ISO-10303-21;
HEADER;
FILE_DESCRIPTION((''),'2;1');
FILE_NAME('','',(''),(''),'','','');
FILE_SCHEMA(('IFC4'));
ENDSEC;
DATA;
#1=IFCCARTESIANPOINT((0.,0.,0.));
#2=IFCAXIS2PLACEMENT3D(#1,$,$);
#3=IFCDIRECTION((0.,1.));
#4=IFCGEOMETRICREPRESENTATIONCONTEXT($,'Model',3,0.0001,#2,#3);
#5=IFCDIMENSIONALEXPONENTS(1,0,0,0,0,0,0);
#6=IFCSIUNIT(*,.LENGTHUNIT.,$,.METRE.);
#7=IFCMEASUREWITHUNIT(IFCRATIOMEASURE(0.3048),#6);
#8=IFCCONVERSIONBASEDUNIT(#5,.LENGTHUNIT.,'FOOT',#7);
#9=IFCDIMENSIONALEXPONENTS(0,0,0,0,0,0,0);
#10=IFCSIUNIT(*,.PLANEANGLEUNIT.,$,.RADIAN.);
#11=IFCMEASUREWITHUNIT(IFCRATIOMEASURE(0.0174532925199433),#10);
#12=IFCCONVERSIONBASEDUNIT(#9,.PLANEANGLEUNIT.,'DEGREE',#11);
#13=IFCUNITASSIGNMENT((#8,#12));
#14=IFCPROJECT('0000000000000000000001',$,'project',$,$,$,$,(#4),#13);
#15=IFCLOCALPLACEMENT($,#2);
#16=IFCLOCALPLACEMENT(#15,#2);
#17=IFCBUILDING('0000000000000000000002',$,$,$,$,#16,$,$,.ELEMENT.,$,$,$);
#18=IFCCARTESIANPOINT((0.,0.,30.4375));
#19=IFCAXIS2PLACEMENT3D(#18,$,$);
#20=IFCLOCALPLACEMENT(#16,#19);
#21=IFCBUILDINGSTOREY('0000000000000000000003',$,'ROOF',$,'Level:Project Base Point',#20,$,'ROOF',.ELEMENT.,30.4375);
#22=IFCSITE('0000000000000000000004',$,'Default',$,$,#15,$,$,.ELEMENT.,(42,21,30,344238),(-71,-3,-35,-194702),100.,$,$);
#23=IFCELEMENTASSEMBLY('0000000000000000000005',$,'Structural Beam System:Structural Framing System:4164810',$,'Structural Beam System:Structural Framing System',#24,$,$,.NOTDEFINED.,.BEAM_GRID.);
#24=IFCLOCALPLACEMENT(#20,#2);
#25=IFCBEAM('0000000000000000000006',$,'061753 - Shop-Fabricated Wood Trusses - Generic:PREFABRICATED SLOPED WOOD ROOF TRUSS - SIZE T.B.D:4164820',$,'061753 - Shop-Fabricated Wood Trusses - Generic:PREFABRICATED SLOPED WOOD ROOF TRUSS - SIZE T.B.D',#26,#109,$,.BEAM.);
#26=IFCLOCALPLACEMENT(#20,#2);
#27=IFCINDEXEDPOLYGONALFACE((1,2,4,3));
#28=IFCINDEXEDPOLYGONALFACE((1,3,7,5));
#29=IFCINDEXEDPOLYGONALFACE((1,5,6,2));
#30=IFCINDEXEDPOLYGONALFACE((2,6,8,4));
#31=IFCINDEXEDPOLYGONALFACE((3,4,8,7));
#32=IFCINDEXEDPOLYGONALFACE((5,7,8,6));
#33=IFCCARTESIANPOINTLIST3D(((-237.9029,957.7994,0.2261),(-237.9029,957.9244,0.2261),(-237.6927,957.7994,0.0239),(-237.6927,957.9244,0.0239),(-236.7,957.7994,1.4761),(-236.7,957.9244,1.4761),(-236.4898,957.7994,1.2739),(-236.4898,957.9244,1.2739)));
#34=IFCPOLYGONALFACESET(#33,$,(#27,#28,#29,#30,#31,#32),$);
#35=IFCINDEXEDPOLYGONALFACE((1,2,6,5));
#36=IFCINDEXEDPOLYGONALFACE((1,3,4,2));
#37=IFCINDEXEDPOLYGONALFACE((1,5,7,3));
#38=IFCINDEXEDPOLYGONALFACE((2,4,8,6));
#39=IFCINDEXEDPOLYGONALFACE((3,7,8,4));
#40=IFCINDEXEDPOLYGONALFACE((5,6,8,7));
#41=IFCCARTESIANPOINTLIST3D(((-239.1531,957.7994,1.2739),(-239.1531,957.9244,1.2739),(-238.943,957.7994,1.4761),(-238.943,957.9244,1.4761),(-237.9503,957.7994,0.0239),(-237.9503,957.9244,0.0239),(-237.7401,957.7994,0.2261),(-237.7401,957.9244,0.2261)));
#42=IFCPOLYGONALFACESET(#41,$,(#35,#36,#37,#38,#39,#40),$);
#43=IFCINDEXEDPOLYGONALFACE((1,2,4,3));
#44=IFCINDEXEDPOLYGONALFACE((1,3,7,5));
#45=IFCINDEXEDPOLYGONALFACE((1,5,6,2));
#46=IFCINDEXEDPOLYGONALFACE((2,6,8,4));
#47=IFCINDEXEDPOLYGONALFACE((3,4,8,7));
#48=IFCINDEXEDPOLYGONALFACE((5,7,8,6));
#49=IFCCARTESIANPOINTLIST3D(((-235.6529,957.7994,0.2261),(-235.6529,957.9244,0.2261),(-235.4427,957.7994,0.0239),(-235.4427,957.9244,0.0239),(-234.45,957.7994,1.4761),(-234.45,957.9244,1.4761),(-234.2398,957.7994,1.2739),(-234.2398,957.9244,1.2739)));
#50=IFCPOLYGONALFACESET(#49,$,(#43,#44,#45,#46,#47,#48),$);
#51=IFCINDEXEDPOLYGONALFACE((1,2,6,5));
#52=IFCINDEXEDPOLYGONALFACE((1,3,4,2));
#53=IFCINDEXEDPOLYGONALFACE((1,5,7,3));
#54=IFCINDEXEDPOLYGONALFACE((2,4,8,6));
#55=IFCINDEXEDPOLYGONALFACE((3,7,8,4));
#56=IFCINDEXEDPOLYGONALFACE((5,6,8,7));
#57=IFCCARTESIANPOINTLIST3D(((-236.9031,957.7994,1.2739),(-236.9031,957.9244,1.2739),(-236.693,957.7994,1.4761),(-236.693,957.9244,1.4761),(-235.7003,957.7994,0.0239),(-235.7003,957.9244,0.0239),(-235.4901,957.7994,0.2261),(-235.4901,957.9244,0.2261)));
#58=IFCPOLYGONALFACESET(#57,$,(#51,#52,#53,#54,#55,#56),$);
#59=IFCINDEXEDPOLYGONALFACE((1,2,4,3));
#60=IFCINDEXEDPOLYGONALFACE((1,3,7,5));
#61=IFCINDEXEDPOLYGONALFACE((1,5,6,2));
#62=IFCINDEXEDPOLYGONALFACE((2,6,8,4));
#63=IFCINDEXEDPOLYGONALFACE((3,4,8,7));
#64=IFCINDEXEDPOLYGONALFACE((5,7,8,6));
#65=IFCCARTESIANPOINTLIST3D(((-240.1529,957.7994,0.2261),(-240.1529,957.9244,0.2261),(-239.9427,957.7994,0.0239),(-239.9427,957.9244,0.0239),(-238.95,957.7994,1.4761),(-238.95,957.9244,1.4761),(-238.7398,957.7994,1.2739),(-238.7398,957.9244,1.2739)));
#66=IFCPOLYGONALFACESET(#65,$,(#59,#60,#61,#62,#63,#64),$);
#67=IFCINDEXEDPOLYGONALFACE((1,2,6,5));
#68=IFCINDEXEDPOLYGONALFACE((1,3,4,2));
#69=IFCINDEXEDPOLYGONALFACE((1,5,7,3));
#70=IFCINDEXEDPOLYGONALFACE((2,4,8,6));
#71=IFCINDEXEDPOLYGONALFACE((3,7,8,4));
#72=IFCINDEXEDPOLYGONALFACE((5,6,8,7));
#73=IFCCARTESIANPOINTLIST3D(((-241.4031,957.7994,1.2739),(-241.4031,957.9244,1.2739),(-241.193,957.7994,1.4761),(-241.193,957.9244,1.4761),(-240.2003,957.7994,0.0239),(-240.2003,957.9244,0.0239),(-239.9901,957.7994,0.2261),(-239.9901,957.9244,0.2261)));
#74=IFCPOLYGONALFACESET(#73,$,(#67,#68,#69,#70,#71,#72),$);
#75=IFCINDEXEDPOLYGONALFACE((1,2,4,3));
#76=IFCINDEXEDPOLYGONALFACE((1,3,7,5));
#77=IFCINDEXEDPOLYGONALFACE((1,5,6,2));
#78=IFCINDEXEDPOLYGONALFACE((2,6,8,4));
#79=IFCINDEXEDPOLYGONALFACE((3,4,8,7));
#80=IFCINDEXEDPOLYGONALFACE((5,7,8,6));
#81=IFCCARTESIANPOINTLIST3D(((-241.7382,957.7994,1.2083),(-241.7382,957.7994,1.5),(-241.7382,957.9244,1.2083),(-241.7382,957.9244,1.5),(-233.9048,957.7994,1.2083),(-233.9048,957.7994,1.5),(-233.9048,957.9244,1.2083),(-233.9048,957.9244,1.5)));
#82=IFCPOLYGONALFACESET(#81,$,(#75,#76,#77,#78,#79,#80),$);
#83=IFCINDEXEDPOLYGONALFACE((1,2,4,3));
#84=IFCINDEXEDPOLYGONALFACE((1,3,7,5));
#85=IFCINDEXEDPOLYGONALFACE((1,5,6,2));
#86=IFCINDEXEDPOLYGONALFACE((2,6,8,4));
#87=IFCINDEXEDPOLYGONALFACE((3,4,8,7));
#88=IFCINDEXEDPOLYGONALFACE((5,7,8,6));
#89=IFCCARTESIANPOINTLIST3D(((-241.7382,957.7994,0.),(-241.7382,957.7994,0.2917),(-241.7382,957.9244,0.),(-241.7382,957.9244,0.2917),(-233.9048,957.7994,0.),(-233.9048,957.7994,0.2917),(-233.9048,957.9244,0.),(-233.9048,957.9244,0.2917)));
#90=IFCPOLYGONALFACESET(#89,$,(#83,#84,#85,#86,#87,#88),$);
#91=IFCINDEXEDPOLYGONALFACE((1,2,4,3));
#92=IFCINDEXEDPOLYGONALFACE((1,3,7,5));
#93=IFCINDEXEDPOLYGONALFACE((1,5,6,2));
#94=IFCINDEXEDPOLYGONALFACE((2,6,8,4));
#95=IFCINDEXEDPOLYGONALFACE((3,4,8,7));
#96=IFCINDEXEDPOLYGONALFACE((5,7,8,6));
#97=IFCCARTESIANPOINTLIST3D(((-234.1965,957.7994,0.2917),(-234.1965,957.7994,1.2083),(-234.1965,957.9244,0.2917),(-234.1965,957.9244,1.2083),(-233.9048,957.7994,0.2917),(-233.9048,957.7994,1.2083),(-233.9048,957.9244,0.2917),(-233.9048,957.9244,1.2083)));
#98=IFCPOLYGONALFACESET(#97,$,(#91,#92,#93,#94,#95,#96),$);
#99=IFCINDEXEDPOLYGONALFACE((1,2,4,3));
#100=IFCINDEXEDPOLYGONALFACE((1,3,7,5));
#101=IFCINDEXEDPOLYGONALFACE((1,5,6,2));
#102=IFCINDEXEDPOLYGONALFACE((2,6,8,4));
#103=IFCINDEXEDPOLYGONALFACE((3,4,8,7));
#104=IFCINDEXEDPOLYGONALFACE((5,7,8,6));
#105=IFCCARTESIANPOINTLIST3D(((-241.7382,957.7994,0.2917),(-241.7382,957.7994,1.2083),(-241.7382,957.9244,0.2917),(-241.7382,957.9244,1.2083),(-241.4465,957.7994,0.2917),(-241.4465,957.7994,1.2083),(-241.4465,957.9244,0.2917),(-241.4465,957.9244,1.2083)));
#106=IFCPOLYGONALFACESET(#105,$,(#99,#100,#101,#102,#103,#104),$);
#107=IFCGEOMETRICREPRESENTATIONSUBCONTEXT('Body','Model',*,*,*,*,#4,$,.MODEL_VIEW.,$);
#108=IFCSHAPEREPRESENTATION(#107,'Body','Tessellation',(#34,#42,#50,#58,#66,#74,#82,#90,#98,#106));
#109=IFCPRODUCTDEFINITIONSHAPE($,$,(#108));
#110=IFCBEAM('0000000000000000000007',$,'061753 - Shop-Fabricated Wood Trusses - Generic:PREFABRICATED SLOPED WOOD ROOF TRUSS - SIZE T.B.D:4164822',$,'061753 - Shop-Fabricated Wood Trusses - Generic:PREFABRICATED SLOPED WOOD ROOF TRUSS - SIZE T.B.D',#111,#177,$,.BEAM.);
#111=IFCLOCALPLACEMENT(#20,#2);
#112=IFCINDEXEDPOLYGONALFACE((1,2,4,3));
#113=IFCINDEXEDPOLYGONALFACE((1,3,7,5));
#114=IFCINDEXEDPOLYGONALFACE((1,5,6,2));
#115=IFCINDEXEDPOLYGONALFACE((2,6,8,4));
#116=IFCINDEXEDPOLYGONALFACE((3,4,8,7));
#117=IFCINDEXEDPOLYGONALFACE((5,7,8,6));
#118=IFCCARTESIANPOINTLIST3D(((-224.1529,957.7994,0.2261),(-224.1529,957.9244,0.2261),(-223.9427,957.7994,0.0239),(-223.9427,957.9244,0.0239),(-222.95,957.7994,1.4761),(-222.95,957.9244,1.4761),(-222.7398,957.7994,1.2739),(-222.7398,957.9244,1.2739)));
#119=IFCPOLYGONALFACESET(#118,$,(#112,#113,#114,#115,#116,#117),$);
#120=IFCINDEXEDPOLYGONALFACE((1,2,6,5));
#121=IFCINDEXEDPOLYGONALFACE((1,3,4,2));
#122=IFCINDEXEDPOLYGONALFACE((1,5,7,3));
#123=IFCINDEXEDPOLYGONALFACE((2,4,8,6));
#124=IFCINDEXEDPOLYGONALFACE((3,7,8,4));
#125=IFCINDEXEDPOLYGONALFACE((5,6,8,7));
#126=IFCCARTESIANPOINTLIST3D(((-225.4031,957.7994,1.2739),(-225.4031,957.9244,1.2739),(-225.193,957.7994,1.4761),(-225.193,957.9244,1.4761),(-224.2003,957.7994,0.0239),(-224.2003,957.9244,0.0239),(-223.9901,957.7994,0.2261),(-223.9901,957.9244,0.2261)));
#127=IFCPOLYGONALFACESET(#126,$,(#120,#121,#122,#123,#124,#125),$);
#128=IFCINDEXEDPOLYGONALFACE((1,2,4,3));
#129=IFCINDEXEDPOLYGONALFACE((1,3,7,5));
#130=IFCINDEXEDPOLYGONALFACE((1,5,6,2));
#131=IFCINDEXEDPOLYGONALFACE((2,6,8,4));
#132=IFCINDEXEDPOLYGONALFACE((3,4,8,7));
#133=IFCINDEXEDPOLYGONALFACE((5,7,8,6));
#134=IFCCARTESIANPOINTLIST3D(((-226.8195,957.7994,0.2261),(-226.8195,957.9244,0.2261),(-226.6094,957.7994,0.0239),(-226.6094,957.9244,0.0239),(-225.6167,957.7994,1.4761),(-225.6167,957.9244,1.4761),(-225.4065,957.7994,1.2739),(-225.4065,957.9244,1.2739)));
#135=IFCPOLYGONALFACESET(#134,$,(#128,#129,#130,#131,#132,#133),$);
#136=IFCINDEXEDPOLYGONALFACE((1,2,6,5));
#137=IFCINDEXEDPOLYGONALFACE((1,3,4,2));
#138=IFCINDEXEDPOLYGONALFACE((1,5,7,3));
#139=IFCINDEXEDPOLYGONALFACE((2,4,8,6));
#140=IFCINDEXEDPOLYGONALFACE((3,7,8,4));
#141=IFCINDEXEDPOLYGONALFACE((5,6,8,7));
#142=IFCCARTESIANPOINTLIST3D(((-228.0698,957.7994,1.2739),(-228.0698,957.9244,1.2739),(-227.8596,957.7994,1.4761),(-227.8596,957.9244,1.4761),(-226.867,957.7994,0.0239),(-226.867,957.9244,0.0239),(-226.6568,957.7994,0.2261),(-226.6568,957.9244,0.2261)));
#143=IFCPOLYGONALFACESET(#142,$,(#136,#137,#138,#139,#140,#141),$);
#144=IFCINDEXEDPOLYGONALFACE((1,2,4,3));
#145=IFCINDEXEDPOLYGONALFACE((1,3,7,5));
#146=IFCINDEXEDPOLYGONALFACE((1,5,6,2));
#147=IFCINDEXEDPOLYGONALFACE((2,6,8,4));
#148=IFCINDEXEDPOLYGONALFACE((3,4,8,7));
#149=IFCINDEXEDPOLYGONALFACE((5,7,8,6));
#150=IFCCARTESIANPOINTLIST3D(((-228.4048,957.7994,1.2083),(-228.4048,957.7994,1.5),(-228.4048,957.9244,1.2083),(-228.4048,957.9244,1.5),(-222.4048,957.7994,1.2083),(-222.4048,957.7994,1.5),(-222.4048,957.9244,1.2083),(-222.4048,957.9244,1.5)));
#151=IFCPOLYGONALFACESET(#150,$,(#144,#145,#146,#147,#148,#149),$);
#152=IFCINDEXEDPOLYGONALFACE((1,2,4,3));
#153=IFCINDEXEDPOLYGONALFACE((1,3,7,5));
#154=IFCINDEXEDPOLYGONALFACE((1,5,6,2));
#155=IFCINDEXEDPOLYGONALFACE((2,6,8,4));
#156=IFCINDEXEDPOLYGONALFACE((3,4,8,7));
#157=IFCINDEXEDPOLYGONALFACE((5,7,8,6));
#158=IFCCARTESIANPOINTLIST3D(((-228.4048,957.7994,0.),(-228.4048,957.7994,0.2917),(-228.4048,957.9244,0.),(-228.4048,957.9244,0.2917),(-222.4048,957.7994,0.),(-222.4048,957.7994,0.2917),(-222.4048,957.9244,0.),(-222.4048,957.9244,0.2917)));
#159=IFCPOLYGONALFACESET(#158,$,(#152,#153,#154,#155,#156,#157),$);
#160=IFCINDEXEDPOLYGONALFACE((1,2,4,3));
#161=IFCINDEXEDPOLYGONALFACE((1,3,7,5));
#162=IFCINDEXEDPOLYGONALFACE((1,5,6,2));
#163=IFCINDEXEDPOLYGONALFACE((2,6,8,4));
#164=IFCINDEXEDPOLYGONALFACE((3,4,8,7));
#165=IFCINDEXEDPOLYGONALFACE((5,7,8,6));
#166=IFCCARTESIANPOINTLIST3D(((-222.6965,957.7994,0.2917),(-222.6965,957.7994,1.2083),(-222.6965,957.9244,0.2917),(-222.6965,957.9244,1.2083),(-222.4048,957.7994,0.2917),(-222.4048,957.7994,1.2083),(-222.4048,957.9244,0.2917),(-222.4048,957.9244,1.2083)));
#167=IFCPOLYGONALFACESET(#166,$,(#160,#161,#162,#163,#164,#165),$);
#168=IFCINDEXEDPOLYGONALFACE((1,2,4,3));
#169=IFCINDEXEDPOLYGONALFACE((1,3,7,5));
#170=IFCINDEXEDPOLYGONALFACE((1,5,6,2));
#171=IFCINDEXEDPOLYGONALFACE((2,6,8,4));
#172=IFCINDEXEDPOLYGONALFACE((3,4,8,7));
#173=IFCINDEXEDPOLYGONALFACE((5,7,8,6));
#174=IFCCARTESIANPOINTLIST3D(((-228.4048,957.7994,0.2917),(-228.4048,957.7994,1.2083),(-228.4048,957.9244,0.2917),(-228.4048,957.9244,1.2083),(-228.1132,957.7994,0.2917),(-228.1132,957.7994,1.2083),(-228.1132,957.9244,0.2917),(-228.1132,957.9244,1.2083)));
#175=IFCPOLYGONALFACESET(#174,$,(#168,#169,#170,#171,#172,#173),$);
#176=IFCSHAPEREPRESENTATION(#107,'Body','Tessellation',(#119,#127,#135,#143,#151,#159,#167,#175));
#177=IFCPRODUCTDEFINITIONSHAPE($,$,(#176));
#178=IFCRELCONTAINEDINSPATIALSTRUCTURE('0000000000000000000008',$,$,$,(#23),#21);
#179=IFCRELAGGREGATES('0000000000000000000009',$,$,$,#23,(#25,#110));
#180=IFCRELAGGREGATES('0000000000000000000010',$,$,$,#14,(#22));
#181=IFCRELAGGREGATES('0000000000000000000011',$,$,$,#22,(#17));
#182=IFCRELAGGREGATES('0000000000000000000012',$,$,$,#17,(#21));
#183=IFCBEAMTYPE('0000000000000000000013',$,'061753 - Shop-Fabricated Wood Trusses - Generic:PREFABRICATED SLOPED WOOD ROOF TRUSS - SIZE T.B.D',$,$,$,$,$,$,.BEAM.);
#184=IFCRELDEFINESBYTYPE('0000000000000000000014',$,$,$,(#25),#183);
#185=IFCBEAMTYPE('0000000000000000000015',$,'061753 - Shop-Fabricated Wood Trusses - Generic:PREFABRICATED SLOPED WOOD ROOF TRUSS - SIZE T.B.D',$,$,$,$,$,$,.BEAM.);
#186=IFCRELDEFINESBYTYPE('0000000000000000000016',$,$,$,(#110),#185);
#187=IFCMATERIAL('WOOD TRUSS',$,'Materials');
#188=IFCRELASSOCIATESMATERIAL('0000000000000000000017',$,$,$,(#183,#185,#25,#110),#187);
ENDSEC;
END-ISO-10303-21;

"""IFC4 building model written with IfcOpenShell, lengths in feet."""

from ifc_helpers import new_model, entity, si_unit, converted_unit, direction, frame, frame_2d, origin, origin_2d_with_axis, place, context, subcontext, project, spatial, rectangle, extrude, source, transform, mapped, material, material_profile, profile_set, profile_usage, type_object, type_shapes, element, aggregate, save


model = new_model("IFC4")

# Units and contexts
model_context = context("Model", 3, precision=0.0001, world=origin(), true_north=direction((0.0, 1.0)))
body_context = subcontext(model_context, "Body", "Model", "MODEL_VIEW")
ifc_project = project(units=[converted_unit("LENGTHUNIT", "FOOT", entity("IfcRatioMeasure", 0.3048), si_unit("LENGTHUNIT", "METRE"), dimensions=[1, 0, 0, 0, 0, 0, 0]), converted_unit("PLANEANGLEUNIT", "DEGREE", entity("IfcRatioMeasure", 0.0174532925199433), si_unit("PLANEANGLEUNIT", "RADIAN"), dimensions=[0, 0, 0, 0, 0, 0, 0])], contexts=[model_context])

# Site, building, storey
site_placement = place(None, origin())
site = spatial("IfcSite", under=ifc_project, at=site_placement, Name="Default", CompositionType="ELEMENT", RefLatitude=(42, 21, 30, 344238), RefLongitude=(-71, -3, -35, -194702), RefElevation=100.0)
building_placement = place(site_placement, origin())
building = spatial("IfcBuilding", under=site, at=building_placement, CompositionType="ELEMENT")
storey_placement = place(building_placement, frame((0.0, 0.0, 30.4375)))
storey = spatial("IfcBuildingStorey", under=building, at=storey_placement, Name="ROOF", ObjectType="Level:Project Base Point", LongName="ROOF", CompositionType="ELEMENT", Elevation=30.4375)

# Element assembly, beams
assembly_1_placement = place(storey_placement, origin())
assembly_1 = element("IfcElementAssembly", 1, at=assembly_1_placement, inside=storey, Name="Structural Beam System:Structural Framing System:4164810", ObjectType="Structural Beam System:Structural Framing System", AssemblyPlace="NOTDEFINED", PredefinedType="BEAM_GRID")
ifc_material_1 = material(Name="WOOD TRUSS", Category="Materials")
ifc_material_profile_1 = material_profile(ifc_material_1, rectangle(XDim=1.7347, YDim=0.125, at=origin_2d_with_axis()), Name="PREFABRICATED SLOPED WOOD ROOF TRUSS - SIZE T.B.D")
ifc_material_profile_2 = material_profile(ifc_material_1, rectangle(XDim=1.7347, YDim=0.125, at=frame_2d((0.0, 0.0), x_axis=(1.0, 0.0))), Name="PREFABRICATED SLOPED WOOD ROOF TRUSS - SIZE T.B.D")
ifc_material_profile_3 = material_profile(ifc_material_1, rectangle(XDim=1.7347, YDim=0.125, at=origin_2d_with_axis()), Name="PREFABRICATED SLOPED WOOD ROOF TRUSS - SIZE T.B.D")
ifc_material_profile_4 = material_profile(ifc_material_1, rectangle(XDim=1.7347, YDim=0.125, at=origin_2d_with_axis()), Name="PREFABRICATED SLOPED WOOD ROOF TRUSS - SIZE T.B.D")
ifc_material_profile_5 = material_profile(ifc_material_1, rectangle(XDim=1.7347, YDim=0.125, at=frame_2d((0.0, 0.0), x_axis=(1.0, 0.0))), Name="PREFABRICATED SLOPED WOOD ROOF TRUSS - SIZE T.B.D")
ifc_material_profile_6 = material_profile(ifc_material_1, rectangle(XDim=1.7347, YDim=0.125, at=frame_2d((0.0, 0.0), x_axis=(1.0, 0.0))), Name="PREFABRICATED SLOPED WOOD ROOF TRUSS - SIZE T.B.D")
ifc_material_profile_7 = material_profile(ifc_material_1, rectangle(XDim=1.7347, YDim=0.125, at=frame_2d((0.0, 0.0), x_axis=(1.0, 0.0))), Name="PREFABRICATED SLOPED WOOD ROOF TRUSS - SIZE T.B.D")
ifc_material_profile_8 = material_profile(ifc_material_1, rectangle(XDim=1.7347, YDim=0.125, at=frame_2d((0.0, 0.0), x_axis=(1.0, 0.0))), Name="PREFABRICATED SLOPED WOOD ROOF TRUSS - SIZE T.B.D")
ifc_material_profile_9 = material_profile(ifc_material_1, rectangle(XDim=1.7347, YDim=0.125, at=origin_2d_with_axis()), Name="PREFABRICATED SLOPED WOOD ROOF TRUSS - SIZE T.B.D")
ifc_material_profile_10 = material_profile(ifc_material_1, rectangle(XDim=1.7347, YDim=0.125, at=frame_2d((0.0, 0.0), x_axis=(1.0, 0.0))), Name="PREFABRICATED SLOPED WOOD ROOF TRUSS - SIZE T.B.D")
ifc_material_profile_11 = material_profile(ifc_material_1, rectangle(XDim=0.2917, YDim=0.125, at=frame_2d((0.0, 0.0), x_axis=(1.0, 0.0))), Name="PREFABRICATED SLOPED WOOD ROOF TRUSS - SIZE T.B.D")
ifc_material_profile_12 = material_profile(ifc_material_1, rectangle(XDim=0.2917, YDim=0.125, at=frame_2d((0.0, 0.0), x_axis=(1.0, 0.0))), Name="PREFABRICATED SLOPED WOOD ROOF TRUSS - SIZE T.B.D")
ifc_material_profile_13 = material_profile(ifc_material_1, rectangle(XDim=0.9167, YDim=0.125, at=frame_2d((0.0, 0.0), x_axis=(1.0, 0.0))), Name="PREFABRICATED SLOPED WOOD ROOF TRUSS - SIZE T.B.D")
ifc_material_profile_14 = material_profile(ifc_material_1, rectangle(XDim=0.9167, YDim=0.125, at=frame_2d((0.0, 0.0), x_axis=(1.0, 0.0))), Name="PREFABRICATED SLOPED WOOD ROOF TRUSS - SIZE T.B.D")
ifc_profile_set_1 = profile_set([ifc_material_profile_1, ifc_material_profile_2, ifc_material_profile_3, ifc_material_profile_4, ifc_material_profile_5, ifc_material_profile_6, ifc_material_profile_7, ifc_material_profile_8, ifc_material_profile_9, ifc_material_profile_10, ifc_material_profile_11, ifc_material_profile_12, ifc_material_profile_13, ifc_material_profile_14], Name="PREFABRICATED SLOPED WOOD ROOF TRUSS - SIZE T.B.D")
ifc_profile_usage_1 = profile_usage(ifc_profile_set_1, cardinal=8)
beam_type_1 = type_object("IfcBeamType", Name="061753 - Shop-Fabricated Wood Trusses - Generic:PREFABRICATED SLOPED WOOD ROOF TRUSS - SIZE T.B.D", PredefinedType="BEAM", material=ifc_profile_set_1)
shared_shape_1 = source(origin(), body_context, "Body", "SweptSolid", [
    extrude(rectangle(XDim=1.7347, YDim=0.125, at=origin_2d_with_axis()), frame((0.5201, 0.0, 0.1011), z_axis=(0.720569, 0.0, -0.693383), x_axis=(0.693383, 0.0, 0.720569)), (0.0, 0.0, 1.0), 0.2917),
    extrude(rectangle(XDim=1.7347, YDim=0.125, at=origin_2d_with_axis()), frame((-0.7302, 0.0, -0.1011), z_axis=(0.720569, 0.0, 0.693383), x_axis=(0.693383, 0.0, -0.720569)), (0.0, 0.0, 1.0), 0.2917),
    extrude(rectangle(XDim=1.7347, YDim=0.125, at=origin_2d_with_axis()), frame((2.7701, 0.0, 0.1011), z_axis=(0.720569, 0.0, -0.693383), x_axis=(0.693383, 0.0, 0.720569)), (0.0, 0.0, 1.0), 0.2917),
    extrude(rectangle(XDim=1.7347, YDim=0.125, at=frame_2d((0.0, 0.0), x_axis=(1.0, 0.0))), frame((1.5198, 0.0, -0.1011), z_axis=(0.720569, 0.0, 0.693383), x_axis=(0.693383, 0.0, -0.720569)), (0.0, 0.0, 1.0), 0.2917),
    extrude(rectangle(XDim=1.7347, YDim=0.125, at=frame_2d((0.0, 0.0), x_axis=(1.0, 0.0))), frame((-1.7299, 0.0, 0.1011), z_axis=(0.720569, 0.0, -0.693383), x_axis=(0.693383, 0.0, 0.720569)), (0.0, 0.0, 1.0), 0.2917),
    extrude(rectangle(XDim=1.7347, YDim=0.125, at=frame_2d((0.0, 0.0), x_axis=(1.0, 0.0))), frame((-2.9802, 0.0, -0.1011), z_axis=(0.720569, 0.0, 0.693383), x_axis=(0.693383, 0.0, -0.720569)), (0.0, 0.0, 1.0), 0.2917),
    extrude(rectangle(XDim=0.2917, YDim=0.125, at=frame_2d((0.0, 0.0), x_axis=(1.0, 0.0))), frame((-3.9167, 0.0, 0.6042), z_axis=(1.0, 0.0, 0.0), x_axis=(0.0, 0.0, -1.0)), (0.0, 0.0, 1.0), 7.8333),
    extrude(rectangle(XDim=0.2917, YDim=0.125, at=frame_2d((0.0, 0.0), x_axis=(1.0, 0.0))), frame((-3.9167, 0.0, -0.6042), z_axis=(1.0, 0.0, 0.0), x_axis=(0.0, 0.0, -1.0)), (0.0, 0.0, 1.0), 7.8333),
    extrude(rectangle(XDim=0.9167, YDim=0.125, at=frame_2d((0.0, 0.0), x_axis=(1.0, 0.0))), frame((3.625, 0.0, 0.0), z_axis=(1.0, 0.0, 0.0), x_axis=(0.0, 0.0, -1.0)), (0.0, 0.0, 1.0), 0.2917),
    extrude(rectangle(XDim=0.9167, YDim=0.125, at=frame_2d((0.0, 0.0), x_axis=(1.0, 0.0))), frame((-3.9167, 0.0, 0.0), z_axis=(1.0, 0.0, 0.0), x_axis=(0.0, 0.0, -1.0)), (0.0, 0.0, 1.0), 0.2917),
])
type_shapes(beam_type_1, [shared_shape_1])
beam_1_placement = place(assembly_1_placement, frame((-237.8215, 957.8619, 0.75)))
beam_1 = element("IfcBeam", 2, at=beam_1_placement, type_object=beam_type_1, material=ifc_profile_usage_1, Name="061753 - Shop-Fabricated Wood Trusses - Generic:PREFABRICATED SLOPED WOOD ROOF TRUSS - SIZE T.B.D:4164820", ObjectType="061753 - Shop-Fabricated Wood Trusses - Generic:PREFABRICATED SLOPED WOOD ROOF TRUSS - SIZE T.B.D", PredefinedType="BEAM", context=body_context, shape_type="MappedRepresentation", body=[
    mapped(shared_shape_1, transform((0.0, 0.0, 0.0), scale=1.0)),
])
ifc_profile_usage_2 = profile_usage(ifc_profile_set_1, cardinal=8)
beam_type_2 = type_object("IfcBeamType", Name="061753 - Shop-Fabricated Wood Trusses - Generic:PREFABRICATED SLOPED WOOD ROOF TRUSS - SIZE T.B.D", PredefinedType="BEAM", material=ifc_profile_set_1)
shared_shape_2 = source(origin(), body_context, "Body", "SweptSolid", [
    extrude(rectangle(XDim=1.7347, YDim=0.125, at=frame_2d((0.0, 0.0), x_axis=(1.0, 0.0))), frame((1.8534, 0.0, 0.1011), z_axis=(0.720569, 0.0, -0.693383), x_axis=(0.693383, 0.0, 0.720569)), (0.0, 0.0, 1.0), 0.2917),
    extrude(rectangle(XDim=1.7347, YDim=0.125, at=frame_2d((0.0, 0.0), x_axis=(1.0, 0.0))), frame((0.6031, 0.0, -0.1011), z_axis=(0.720569, 0.0, 0.693383), x_axis=(0.693383, 0.0, -0.720569)), (0.0, 0.0, 1.0), 0.2917),
    extrude(rectangle(XDim=1.7347, YDim=0.125, at=frame_2d((0.0, 0.0), x_axis=(1.0, 0.0))), frame((-0.8133, 0.0, 0.1011), z_axis=(0.720569, 0.0, -0.693383), x_axis=(0.693383, 0.0, 0.720569)), (0.0, 0.0, 1.0), 0.2917),
    extrude(rectangle(XDim=1.7347, YDim=0.125, at=frame_2d((0.0, 0.0), x_axis=(1.0, 0.0))), frame((-2.0636, 0.0, -0.1011), z_axis=(0.720569, 0.0, 0.693383), x_axis=(0.693383, 0.0, -0.720569)), (0.0, 0.0, 1.0), 0.2917),
    extrude(rectangle(XDim=0.2917, YDim=0.125, at=frame_2d((0.0, 0.0), x_axis=(1.0, 0.0))), frame((-3.0, 0.0, 0.6042), z_axis=(1.0, 0.0, 0.0), x_axis=(0.0, 0.0, -1.0)), (0.0, 0.0, 1.0), 6.0),
    extrude(rectangle(XDim=0.2917, YDim=0.125, at=frame_2d((0.0, 0.0), x_axis=(1.0, 0.0))), frame((-3.0, 0.0, -0.6042), z_axis=(1.0, 0.0, 0.0), x_axis=(0.0, 0.0, -1.0)), (0.0, 0.0, 1.0), 6.0),
    extrude(rectangle(XDim=0.9167, YDim=0.125, at=frame_2d((0.0, 0.0), x_axis=(1.0, 0.0))), frame((2.7083, 0.0, 0.0), z_axis=(1.0, 0.0, 0.0), x_axis=(0.0, 0.0, -1.0)), (0.0, 0.0, 1.0), 0.2917),
    extrude(rectangle(XDim=0.9167, YDim=0.125, at=frame_2d((0.0, 0.0), x_axis=(1.0, 0.0))), frame((-3.0, 0.0, 0.0), z_axis=(1.0, 0.0, 0.0), x_axis=(0.0, 0.0, -1.0)), (0.0, 0.0, 1.0), 0.2917),
])
type_shapes(beam_type_2, [shared_shape_2])
beam_2_placement = place(assembly_1_placement, frame((-225.4048, 957.8619, 0.75)))
beam_2 = element("IfcBeam", 3, at=beam_2_placement, type_object=beam_type_2, material=ifc_profile_usage_2, Name="061753 - Shop-Fabricated Wood Trusses - Generic:PREFABRICATED SLOPED WOOD ROOF TRUSS - SIZE T.B.D:4164822", ObjectType="061753 - Shop-Fabricated Wood Trusses - Generic:PREFABRICATED SLOPED WOOD ROOF TRUSS - SIZE T.B.D", PredefinedType="BEAM", context=body_context, shape_type="MappedRepresentation", body=[
    mapped(shared_shape_2, transform((0.0, 0.0, 0.0), scale=1.0)),
])
aggregate(assembly_1, [beam_1, beam_2])

save(model, "model.ifc")
